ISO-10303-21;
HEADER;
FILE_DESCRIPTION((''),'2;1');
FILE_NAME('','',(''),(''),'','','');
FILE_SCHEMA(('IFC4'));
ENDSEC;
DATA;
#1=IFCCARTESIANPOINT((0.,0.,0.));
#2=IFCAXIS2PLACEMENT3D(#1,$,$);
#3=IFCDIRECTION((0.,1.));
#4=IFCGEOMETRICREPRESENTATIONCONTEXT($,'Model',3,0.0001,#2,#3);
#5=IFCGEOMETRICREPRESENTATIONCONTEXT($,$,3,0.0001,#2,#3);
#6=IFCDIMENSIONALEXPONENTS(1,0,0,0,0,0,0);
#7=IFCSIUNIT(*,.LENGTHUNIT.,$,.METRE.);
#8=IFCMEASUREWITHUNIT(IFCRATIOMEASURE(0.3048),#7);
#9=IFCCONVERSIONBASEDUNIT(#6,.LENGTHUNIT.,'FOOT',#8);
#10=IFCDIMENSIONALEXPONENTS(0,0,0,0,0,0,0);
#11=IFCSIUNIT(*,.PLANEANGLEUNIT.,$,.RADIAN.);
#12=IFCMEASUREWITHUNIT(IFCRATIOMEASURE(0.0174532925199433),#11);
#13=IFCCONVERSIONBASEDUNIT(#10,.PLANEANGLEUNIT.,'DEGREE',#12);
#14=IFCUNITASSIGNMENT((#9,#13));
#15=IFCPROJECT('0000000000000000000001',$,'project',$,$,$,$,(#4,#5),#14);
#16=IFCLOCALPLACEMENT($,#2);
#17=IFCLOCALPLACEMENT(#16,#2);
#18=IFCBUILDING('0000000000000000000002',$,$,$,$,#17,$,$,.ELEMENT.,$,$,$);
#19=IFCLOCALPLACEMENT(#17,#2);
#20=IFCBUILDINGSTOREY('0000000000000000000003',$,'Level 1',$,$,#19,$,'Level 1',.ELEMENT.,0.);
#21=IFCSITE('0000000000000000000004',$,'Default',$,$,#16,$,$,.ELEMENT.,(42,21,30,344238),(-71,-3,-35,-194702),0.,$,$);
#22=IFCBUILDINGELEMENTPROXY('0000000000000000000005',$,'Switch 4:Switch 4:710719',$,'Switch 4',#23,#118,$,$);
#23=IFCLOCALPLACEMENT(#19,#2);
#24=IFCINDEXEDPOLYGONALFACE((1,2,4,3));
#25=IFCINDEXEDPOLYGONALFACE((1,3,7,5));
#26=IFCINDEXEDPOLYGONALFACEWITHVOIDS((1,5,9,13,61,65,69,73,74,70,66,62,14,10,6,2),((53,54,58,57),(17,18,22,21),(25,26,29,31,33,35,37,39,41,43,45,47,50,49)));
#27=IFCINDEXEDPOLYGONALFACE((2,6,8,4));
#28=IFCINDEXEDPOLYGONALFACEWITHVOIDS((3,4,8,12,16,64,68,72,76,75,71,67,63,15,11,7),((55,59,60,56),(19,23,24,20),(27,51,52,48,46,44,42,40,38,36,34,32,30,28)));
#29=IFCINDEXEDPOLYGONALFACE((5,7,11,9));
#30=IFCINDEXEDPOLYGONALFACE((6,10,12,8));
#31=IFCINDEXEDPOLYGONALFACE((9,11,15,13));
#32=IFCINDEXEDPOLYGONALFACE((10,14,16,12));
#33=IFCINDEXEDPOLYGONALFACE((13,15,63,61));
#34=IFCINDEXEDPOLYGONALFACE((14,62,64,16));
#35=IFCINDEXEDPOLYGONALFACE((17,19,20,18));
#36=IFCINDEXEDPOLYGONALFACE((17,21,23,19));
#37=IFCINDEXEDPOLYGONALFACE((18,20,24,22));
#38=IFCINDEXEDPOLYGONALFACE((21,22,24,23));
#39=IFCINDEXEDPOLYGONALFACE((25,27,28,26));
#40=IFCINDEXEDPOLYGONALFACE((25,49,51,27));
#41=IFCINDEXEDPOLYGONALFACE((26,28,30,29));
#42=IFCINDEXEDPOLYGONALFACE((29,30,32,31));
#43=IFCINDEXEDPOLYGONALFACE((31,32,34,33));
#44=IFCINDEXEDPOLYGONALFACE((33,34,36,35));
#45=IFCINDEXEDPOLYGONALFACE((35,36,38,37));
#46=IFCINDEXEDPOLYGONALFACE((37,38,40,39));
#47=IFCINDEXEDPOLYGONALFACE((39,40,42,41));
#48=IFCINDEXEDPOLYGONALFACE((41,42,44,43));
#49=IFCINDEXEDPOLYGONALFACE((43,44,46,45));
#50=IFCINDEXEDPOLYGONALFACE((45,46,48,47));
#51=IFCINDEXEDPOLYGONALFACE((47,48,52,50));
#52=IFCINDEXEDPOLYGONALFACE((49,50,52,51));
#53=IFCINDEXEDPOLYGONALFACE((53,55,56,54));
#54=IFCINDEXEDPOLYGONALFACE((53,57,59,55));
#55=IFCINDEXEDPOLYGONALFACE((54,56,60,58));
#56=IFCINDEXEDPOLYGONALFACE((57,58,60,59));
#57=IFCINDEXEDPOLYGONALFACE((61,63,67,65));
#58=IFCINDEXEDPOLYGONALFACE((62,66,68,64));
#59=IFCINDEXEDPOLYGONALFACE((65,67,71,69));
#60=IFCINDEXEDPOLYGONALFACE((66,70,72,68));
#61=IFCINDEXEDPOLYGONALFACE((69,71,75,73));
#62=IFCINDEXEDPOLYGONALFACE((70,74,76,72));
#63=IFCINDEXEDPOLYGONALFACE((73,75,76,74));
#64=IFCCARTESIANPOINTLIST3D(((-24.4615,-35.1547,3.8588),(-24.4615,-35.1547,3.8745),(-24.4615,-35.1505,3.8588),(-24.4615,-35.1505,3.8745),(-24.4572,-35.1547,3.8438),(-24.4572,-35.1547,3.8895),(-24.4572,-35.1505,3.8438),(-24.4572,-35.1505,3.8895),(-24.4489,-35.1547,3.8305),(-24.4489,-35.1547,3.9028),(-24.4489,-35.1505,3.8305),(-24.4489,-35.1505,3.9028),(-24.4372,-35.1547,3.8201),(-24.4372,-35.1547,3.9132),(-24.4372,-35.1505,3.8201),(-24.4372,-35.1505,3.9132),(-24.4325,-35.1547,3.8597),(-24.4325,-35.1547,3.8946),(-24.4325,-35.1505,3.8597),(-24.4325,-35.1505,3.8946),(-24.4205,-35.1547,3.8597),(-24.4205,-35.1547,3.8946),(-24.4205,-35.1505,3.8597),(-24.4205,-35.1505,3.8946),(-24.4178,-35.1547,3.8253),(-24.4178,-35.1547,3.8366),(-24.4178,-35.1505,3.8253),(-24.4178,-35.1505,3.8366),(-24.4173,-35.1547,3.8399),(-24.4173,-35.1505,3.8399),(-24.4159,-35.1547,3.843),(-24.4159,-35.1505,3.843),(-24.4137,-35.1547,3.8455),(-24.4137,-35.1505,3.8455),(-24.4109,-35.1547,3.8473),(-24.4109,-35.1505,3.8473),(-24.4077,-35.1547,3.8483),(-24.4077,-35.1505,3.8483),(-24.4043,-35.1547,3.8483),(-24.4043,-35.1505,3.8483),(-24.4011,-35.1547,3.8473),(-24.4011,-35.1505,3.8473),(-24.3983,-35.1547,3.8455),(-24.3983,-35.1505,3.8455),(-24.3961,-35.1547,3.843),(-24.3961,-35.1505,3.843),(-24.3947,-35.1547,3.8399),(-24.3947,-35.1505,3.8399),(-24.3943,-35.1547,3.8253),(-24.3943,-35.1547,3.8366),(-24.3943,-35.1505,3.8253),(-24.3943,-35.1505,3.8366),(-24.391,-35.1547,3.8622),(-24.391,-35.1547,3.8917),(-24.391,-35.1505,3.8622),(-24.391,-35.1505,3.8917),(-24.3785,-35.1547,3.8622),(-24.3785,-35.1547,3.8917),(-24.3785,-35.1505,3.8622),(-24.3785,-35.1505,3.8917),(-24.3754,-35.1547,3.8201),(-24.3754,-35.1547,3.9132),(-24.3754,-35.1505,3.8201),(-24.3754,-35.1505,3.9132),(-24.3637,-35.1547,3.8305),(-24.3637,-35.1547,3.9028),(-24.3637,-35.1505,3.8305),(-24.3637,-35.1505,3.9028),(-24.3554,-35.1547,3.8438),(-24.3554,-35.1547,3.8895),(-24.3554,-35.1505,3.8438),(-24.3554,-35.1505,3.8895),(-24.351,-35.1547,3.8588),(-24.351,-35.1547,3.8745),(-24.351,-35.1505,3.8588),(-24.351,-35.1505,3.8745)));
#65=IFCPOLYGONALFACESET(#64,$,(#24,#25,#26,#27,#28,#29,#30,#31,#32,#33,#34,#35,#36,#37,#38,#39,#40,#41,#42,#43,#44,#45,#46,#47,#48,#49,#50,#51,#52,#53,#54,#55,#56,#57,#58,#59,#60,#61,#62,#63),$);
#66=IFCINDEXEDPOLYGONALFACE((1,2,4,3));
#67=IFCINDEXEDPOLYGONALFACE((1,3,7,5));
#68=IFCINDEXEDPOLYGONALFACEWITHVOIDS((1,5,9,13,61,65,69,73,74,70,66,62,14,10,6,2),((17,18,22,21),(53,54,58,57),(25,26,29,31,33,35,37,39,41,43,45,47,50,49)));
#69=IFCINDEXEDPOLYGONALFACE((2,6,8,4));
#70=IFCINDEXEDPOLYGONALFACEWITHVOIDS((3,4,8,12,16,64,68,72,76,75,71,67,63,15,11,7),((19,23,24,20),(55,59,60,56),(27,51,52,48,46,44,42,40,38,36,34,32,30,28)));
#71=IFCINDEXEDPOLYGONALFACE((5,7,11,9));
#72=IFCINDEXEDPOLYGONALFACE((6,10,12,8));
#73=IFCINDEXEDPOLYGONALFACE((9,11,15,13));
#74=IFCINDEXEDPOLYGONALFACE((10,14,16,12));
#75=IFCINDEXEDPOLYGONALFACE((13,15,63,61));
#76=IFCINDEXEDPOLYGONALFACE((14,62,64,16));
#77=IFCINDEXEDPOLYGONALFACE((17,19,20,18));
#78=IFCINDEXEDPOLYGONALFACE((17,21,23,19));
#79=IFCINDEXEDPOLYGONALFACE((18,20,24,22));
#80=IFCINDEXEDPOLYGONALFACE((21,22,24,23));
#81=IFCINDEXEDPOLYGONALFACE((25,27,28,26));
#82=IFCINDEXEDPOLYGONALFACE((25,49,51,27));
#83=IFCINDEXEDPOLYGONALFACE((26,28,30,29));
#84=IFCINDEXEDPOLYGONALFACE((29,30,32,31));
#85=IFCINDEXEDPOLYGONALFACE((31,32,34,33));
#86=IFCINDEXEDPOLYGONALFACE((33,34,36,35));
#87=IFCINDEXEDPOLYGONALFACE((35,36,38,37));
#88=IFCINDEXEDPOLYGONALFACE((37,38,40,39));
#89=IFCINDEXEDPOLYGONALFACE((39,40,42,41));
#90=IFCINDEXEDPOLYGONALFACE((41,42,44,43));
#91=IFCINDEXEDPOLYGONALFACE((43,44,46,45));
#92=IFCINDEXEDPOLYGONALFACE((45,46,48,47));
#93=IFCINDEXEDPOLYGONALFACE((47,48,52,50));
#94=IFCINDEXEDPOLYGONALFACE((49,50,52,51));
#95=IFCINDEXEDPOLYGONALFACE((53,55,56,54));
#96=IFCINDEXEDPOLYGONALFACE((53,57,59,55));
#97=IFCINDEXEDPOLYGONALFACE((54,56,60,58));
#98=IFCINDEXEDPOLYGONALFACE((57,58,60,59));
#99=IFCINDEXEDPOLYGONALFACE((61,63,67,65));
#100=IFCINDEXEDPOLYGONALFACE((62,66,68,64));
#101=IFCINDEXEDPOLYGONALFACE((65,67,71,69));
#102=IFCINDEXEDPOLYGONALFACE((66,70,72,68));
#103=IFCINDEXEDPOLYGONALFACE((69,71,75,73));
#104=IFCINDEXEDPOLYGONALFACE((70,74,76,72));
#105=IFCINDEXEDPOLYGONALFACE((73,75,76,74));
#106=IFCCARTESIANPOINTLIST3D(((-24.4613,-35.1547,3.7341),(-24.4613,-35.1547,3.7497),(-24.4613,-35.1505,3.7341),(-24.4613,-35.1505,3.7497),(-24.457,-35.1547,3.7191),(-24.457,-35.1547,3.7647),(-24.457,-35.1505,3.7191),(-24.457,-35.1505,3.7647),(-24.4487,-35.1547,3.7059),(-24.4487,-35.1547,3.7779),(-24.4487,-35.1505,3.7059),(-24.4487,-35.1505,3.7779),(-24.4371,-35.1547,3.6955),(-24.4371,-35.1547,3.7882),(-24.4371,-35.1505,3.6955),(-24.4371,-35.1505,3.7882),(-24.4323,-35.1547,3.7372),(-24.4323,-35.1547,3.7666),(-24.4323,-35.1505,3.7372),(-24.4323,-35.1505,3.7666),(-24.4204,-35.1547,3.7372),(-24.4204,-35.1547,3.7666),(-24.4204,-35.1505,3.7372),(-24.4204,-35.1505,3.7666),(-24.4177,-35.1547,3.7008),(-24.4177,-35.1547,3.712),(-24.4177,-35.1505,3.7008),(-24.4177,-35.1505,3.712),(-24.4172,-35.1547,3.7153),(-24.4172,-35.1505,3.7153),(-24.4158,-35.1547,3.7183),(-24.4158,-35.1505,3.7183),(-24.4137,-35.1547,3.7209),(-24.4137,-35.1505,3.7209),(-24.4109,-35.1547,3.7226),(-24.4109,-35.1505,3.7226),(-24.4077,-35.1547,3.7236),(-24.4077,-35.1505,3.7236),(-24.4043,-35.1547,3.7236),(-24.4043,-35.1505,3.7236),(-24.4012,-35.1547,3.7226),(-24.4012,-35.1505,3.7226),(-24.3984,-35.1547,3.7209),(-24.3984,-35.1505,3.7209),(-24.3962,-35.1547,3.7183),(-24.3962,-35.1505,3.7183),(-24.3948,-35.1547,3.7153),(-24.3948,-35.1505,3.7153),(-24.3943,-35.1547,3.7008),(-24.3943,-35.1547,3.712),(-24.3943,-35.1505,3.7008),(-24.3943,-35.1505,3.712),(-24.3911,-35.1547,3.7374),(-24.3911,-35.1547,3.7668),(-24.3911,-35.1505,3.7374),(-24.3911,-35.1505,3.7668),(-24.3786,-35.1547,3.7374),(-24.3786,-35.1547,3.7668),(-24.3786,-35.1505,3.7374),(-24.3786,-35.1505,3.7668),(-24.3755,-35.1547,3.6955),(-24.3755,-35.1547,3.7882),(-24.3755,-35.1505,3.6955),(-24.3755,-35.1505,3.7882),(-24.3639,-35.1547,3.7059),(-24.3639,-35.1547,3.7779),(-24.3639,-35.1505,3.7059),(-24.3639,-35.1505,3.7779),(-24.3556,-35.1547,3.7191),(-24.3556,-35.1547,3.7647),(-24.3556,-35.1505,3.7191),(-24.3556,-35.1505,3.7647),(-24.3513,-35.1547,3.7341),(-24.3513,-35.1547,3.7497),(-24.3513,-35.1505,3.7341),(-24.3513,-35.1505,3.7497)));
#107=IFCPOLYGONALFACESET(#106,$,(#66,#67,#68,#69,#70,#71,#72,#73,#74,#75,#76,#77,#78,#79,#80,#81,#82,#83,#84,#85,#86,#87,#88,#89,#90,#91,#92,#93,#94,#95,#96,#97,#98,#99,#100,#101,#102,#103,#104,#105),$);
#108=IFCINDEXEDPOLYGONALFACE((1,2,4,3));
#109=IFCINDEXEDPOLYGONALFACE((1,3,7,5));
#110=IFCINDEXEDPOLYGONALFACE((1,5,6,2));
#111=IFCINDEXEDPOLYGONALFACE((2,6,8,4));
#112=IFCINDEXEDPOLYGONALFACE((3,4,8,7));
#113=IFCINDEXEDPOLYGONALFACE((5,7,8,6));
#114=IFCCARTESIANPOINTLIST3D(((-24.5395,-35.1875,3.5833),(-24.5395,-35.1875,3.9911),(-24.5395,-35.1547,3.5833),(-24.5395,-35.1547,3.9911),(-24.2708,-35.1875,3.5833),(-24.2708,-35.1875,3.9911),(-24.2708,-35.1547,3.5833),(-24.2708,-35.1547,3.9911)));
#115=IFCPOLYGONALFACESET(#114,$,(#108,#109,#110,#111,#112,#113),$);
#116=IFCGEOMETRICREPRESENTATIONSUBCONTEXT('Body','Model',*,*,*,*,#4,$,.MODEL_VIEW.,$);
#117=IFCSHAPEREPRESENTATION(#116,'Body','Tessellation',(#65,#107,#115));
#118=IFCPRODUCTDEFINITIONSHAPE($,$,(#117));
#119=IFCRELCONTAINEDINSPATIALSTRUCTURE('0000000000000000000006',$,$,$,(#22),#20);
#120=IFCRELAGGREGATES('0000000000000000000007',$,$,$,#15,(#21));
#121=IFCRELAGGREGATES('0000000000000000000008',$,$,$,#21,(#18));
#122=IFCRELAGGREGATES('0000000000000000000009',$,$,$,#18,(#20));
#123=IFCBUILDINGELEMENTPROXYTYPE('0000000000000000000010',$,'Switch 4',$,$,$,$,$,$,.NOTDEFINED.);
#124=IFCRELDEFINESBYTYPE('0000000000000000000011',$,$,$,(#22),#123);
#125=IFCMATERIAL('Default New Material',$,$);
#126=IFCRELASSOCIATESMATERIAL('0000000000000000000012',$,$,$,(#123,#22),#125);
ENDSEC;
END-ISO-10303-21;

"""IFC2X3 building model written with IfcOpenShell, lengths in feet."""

from ifc_helpers import new_model, entity, si_unit, converted_unit, direction, frame, frame_2d, origin, origin_2d_with_axis, place, context, subcontext, project, spatial, polyline, circle_curve, parameter, trimmed, segment, composite_curve, rectangle, outline, extrude, source, transform, mapped, material, type_object, type_shapes, element, save


model = new_model("IFC2X3")

# Units and contexts
model_context = context("Model", 3, precision=0.0001, world=origin(), true_north=direction((0.0, 1.0)))
context_of_model = context(None, 3, precision=0.0001, world=origin(), true_north=direction((0.0, 1.0)))
body_context = subcontext(model_context, "Body", "Model", "MODEL_VIEW")
ifc_project = project(units=[converted_unit("LENGTHUNIT", "FOOT", entity("IfcRatioMeasure", 0.3048), si_unit("LENGTHUNIT", "METRE"), dimensions=[1, 0, 0, 0, 0, 0, 0]), converted_unit("PLANEANGLEUNIT", "DEGREE", entity("IfcRatioMeasure", 0.0174532925199433), si_unit("PLANEANGLEUNIT", "RADIAN"), dimensions=[0, 0, 0, 0, 0, 0, 0])], contexts=[model_context, context_of_model])

# Site, building, storey
site_placement = place(None, origin())
site = spatial("IfcSite", under=ifc_project, at=site_placement, Name="Default", CompositionType="ELEMENT", RefLatitude=(42, 21, 30, 344238), RefLongitude=(-71, -3, -35, -194702), RefElevation=0.0)
building_placement = place(site_placement, origin())
building = spatial("IfcBuilding", under=site, at=building_placement, CompositionType="ELEMENT")
storey_placement = place(building_placement, origin())
storey = spatial("IfcBuildingStorey", under=building, at=storey_placement, Name="Level 1", LongName="Level 1", CompositionType="ELEMENT", Elevation=0.0)

# Shared definitions
ifc_material = material(Name="Default New Material")

# Building element proxy
building_element_proxy_type_1 = type_object("IfcBuildingElementProxyType", Name="Switch 4", PredefinedType="NOTDEFINED", material=ifc_material)
shared_shape_1 = source(origin(), body_context, "Body", "SweptSolid", [
    extrude(outline(composite_curve([segment(polyline([(-0.0309, -0.0466), (0.0309, -0.0466)]), True, "CONTINUOUS"), segment(trimmed(circle_curve(frame_2d((-0.0003, 0.0), x_axis=(-1.0, 0.0)), 0.0561), [parameter(123.794741)], [parameter(236.205259)], True, "PARAMETER"), True, "CONTINUOUS"), segment(polyline([(0.0309, 0.0466), (-0.0309, 0.0466)]), True, "CONTINUOUS"), segment(trimmed(circle_curve(frame_2d((0.0003, 0.0), x_axis=(1.0, 0.0)), 0.0561), [parameter(123.794741)], [parameter(236.205259)], True, "PARAMETER"), True, "CONTINUOUS")], self_intersect=False), holes=[polyline([(0.0142, 0.0279), (0.0262, 0.0279), (0.0262, -0.0069), (0.0142, -0.0069), (0.0142, 0.0279)]), polyline([(-0.0153, 0.025), (-0.0153, -0.0045), (-0.0278, -0.0045), (-0.0278, 0.025), (-0.0153, 0.025)]), composite_curve([segment(polyline([(-0.012, -0.0413), (-0.012, -0.03)]), True, "CONTINUOUS"), segment(trimmed(circle_curve(frame_2d((-0.0003, -0.03), x_axis=(-1.0, 0.0)), 0.0117), [parameter(180.0)], [parameter(0.0)], True, "PARAMETER"), False, "CONTINUOUS"), segment(polyline([(0.0115, -0.03), (0.0115, -0.0413)]), True, "CONTINUOUS"), segment(polyline([(0.0115, -0.0413), (-0.012, -0.0413)]), True, "CONTINUOUS")], self_intersect=False)]), frame((-0.0011, 0.0328, 0.2833), z_axis=(0.0, 1.0, 0.0), x_axis=(-1.0, 0.0, 0.0)), (0.0, 0.0, 1.0), 0.0042),
    extrude(outline(composite_curve([segment(polyline([(-0.0308, -0.0464), (0.0308, -0.0464)]), True, "CONTINUOUS"), segment(trimmed(circle_curve(frame_2d((-0.0003, 0.0), x_axis=(-1.0, 0.0)), 0.0558), [parameter(123.794741)], [parameter(236.205259)], True, "PARAMETER"), True, "CONTINUOUS"), segment(polyline([(0.0308, 0.0464), (-0.0308, 0.0464)]), True, "CONTINUOUS"), segment(trimmed(circle_curve(frame_2d((0.0003, 0.0), x_axis=(1.0, 0.0)), 0.0558), [parameter(123.794741)], [parameter(236.205259)], True, "PARAMETER"), True, "CONTINUOUS")], self_intersect=False), holes=[polyline([(0.0141, 0.0247), (0.026, 0.0247), (0.026, -0.0047), (0.0141, -0.0047), (0.0141, 0.0247)]), polyline([(-0.0152, 0.0249), (-0.0152, -0.0045), (-0.0277, -0.0045), (-0.0277, 0.0249), (-0.0152, 0.0249)]), composite_curve([segment(polyline([(-0.012, -0.0411), (-0.012, -0.0299)]), True, "CONTINUOUS"), segment(trimmed(circle_curve(frame_2d((-0.0003, -0.0299), x_axis=(-1.0, 0.0)), 0.0117), [parameter(180.0)], [parameter(0.0)], True, "PARAMETER"), False, "CONTINUOUS"), segment(polyline([(0.0114, -0.0299), (0.0114, -0.0411)]), True, "CONTINUOUS"), segment(polyline([(0.0114, -0.0411), (-0.012, -0.0411)]), True, "CONTINUOUS")], self_intersect=False)]), frame((-0.0011, 0.0328, 0.1586), z_axis=(0.0, 1.0, 0.0), x_axis=(-1.0, 0.0, 0.0)), (0.0, 0.0, 1.0), 0.0042),
    extrude(rectangle(XDim=0.0328, YDim=0.2687, at=origin_2d_with_axis()), frame((0.0, 0.0164, 0.0), z_axis=(0.0, 0.0, 1.0), x_axis=(0.0, -1.0, 0.0)), (0.0, 0.0, 1.0), 0.4078),
])
type_shapes(building_element_proxy_type_1, [shared_shape_1])
for number, where, name in (
    (1, (-24.4052, -35.1875, 3.5833), "Switch 4:Switch 4:710719"),
):
    element("IfcBuildingElementProxy", number, at=place(storey_placement, frame(where)), inside=storey, type_object=building_element_proxy_type_1, material=ifc_material, Name=name, ObjectType="Switch 4", context=body_context, shape_type="MappedRepresentation", body=[
        mapped(shared_shape_1, transform((0.0, 0.0, 0.0), scale=1.0)),
    ])

save(model, "model.ifc")
